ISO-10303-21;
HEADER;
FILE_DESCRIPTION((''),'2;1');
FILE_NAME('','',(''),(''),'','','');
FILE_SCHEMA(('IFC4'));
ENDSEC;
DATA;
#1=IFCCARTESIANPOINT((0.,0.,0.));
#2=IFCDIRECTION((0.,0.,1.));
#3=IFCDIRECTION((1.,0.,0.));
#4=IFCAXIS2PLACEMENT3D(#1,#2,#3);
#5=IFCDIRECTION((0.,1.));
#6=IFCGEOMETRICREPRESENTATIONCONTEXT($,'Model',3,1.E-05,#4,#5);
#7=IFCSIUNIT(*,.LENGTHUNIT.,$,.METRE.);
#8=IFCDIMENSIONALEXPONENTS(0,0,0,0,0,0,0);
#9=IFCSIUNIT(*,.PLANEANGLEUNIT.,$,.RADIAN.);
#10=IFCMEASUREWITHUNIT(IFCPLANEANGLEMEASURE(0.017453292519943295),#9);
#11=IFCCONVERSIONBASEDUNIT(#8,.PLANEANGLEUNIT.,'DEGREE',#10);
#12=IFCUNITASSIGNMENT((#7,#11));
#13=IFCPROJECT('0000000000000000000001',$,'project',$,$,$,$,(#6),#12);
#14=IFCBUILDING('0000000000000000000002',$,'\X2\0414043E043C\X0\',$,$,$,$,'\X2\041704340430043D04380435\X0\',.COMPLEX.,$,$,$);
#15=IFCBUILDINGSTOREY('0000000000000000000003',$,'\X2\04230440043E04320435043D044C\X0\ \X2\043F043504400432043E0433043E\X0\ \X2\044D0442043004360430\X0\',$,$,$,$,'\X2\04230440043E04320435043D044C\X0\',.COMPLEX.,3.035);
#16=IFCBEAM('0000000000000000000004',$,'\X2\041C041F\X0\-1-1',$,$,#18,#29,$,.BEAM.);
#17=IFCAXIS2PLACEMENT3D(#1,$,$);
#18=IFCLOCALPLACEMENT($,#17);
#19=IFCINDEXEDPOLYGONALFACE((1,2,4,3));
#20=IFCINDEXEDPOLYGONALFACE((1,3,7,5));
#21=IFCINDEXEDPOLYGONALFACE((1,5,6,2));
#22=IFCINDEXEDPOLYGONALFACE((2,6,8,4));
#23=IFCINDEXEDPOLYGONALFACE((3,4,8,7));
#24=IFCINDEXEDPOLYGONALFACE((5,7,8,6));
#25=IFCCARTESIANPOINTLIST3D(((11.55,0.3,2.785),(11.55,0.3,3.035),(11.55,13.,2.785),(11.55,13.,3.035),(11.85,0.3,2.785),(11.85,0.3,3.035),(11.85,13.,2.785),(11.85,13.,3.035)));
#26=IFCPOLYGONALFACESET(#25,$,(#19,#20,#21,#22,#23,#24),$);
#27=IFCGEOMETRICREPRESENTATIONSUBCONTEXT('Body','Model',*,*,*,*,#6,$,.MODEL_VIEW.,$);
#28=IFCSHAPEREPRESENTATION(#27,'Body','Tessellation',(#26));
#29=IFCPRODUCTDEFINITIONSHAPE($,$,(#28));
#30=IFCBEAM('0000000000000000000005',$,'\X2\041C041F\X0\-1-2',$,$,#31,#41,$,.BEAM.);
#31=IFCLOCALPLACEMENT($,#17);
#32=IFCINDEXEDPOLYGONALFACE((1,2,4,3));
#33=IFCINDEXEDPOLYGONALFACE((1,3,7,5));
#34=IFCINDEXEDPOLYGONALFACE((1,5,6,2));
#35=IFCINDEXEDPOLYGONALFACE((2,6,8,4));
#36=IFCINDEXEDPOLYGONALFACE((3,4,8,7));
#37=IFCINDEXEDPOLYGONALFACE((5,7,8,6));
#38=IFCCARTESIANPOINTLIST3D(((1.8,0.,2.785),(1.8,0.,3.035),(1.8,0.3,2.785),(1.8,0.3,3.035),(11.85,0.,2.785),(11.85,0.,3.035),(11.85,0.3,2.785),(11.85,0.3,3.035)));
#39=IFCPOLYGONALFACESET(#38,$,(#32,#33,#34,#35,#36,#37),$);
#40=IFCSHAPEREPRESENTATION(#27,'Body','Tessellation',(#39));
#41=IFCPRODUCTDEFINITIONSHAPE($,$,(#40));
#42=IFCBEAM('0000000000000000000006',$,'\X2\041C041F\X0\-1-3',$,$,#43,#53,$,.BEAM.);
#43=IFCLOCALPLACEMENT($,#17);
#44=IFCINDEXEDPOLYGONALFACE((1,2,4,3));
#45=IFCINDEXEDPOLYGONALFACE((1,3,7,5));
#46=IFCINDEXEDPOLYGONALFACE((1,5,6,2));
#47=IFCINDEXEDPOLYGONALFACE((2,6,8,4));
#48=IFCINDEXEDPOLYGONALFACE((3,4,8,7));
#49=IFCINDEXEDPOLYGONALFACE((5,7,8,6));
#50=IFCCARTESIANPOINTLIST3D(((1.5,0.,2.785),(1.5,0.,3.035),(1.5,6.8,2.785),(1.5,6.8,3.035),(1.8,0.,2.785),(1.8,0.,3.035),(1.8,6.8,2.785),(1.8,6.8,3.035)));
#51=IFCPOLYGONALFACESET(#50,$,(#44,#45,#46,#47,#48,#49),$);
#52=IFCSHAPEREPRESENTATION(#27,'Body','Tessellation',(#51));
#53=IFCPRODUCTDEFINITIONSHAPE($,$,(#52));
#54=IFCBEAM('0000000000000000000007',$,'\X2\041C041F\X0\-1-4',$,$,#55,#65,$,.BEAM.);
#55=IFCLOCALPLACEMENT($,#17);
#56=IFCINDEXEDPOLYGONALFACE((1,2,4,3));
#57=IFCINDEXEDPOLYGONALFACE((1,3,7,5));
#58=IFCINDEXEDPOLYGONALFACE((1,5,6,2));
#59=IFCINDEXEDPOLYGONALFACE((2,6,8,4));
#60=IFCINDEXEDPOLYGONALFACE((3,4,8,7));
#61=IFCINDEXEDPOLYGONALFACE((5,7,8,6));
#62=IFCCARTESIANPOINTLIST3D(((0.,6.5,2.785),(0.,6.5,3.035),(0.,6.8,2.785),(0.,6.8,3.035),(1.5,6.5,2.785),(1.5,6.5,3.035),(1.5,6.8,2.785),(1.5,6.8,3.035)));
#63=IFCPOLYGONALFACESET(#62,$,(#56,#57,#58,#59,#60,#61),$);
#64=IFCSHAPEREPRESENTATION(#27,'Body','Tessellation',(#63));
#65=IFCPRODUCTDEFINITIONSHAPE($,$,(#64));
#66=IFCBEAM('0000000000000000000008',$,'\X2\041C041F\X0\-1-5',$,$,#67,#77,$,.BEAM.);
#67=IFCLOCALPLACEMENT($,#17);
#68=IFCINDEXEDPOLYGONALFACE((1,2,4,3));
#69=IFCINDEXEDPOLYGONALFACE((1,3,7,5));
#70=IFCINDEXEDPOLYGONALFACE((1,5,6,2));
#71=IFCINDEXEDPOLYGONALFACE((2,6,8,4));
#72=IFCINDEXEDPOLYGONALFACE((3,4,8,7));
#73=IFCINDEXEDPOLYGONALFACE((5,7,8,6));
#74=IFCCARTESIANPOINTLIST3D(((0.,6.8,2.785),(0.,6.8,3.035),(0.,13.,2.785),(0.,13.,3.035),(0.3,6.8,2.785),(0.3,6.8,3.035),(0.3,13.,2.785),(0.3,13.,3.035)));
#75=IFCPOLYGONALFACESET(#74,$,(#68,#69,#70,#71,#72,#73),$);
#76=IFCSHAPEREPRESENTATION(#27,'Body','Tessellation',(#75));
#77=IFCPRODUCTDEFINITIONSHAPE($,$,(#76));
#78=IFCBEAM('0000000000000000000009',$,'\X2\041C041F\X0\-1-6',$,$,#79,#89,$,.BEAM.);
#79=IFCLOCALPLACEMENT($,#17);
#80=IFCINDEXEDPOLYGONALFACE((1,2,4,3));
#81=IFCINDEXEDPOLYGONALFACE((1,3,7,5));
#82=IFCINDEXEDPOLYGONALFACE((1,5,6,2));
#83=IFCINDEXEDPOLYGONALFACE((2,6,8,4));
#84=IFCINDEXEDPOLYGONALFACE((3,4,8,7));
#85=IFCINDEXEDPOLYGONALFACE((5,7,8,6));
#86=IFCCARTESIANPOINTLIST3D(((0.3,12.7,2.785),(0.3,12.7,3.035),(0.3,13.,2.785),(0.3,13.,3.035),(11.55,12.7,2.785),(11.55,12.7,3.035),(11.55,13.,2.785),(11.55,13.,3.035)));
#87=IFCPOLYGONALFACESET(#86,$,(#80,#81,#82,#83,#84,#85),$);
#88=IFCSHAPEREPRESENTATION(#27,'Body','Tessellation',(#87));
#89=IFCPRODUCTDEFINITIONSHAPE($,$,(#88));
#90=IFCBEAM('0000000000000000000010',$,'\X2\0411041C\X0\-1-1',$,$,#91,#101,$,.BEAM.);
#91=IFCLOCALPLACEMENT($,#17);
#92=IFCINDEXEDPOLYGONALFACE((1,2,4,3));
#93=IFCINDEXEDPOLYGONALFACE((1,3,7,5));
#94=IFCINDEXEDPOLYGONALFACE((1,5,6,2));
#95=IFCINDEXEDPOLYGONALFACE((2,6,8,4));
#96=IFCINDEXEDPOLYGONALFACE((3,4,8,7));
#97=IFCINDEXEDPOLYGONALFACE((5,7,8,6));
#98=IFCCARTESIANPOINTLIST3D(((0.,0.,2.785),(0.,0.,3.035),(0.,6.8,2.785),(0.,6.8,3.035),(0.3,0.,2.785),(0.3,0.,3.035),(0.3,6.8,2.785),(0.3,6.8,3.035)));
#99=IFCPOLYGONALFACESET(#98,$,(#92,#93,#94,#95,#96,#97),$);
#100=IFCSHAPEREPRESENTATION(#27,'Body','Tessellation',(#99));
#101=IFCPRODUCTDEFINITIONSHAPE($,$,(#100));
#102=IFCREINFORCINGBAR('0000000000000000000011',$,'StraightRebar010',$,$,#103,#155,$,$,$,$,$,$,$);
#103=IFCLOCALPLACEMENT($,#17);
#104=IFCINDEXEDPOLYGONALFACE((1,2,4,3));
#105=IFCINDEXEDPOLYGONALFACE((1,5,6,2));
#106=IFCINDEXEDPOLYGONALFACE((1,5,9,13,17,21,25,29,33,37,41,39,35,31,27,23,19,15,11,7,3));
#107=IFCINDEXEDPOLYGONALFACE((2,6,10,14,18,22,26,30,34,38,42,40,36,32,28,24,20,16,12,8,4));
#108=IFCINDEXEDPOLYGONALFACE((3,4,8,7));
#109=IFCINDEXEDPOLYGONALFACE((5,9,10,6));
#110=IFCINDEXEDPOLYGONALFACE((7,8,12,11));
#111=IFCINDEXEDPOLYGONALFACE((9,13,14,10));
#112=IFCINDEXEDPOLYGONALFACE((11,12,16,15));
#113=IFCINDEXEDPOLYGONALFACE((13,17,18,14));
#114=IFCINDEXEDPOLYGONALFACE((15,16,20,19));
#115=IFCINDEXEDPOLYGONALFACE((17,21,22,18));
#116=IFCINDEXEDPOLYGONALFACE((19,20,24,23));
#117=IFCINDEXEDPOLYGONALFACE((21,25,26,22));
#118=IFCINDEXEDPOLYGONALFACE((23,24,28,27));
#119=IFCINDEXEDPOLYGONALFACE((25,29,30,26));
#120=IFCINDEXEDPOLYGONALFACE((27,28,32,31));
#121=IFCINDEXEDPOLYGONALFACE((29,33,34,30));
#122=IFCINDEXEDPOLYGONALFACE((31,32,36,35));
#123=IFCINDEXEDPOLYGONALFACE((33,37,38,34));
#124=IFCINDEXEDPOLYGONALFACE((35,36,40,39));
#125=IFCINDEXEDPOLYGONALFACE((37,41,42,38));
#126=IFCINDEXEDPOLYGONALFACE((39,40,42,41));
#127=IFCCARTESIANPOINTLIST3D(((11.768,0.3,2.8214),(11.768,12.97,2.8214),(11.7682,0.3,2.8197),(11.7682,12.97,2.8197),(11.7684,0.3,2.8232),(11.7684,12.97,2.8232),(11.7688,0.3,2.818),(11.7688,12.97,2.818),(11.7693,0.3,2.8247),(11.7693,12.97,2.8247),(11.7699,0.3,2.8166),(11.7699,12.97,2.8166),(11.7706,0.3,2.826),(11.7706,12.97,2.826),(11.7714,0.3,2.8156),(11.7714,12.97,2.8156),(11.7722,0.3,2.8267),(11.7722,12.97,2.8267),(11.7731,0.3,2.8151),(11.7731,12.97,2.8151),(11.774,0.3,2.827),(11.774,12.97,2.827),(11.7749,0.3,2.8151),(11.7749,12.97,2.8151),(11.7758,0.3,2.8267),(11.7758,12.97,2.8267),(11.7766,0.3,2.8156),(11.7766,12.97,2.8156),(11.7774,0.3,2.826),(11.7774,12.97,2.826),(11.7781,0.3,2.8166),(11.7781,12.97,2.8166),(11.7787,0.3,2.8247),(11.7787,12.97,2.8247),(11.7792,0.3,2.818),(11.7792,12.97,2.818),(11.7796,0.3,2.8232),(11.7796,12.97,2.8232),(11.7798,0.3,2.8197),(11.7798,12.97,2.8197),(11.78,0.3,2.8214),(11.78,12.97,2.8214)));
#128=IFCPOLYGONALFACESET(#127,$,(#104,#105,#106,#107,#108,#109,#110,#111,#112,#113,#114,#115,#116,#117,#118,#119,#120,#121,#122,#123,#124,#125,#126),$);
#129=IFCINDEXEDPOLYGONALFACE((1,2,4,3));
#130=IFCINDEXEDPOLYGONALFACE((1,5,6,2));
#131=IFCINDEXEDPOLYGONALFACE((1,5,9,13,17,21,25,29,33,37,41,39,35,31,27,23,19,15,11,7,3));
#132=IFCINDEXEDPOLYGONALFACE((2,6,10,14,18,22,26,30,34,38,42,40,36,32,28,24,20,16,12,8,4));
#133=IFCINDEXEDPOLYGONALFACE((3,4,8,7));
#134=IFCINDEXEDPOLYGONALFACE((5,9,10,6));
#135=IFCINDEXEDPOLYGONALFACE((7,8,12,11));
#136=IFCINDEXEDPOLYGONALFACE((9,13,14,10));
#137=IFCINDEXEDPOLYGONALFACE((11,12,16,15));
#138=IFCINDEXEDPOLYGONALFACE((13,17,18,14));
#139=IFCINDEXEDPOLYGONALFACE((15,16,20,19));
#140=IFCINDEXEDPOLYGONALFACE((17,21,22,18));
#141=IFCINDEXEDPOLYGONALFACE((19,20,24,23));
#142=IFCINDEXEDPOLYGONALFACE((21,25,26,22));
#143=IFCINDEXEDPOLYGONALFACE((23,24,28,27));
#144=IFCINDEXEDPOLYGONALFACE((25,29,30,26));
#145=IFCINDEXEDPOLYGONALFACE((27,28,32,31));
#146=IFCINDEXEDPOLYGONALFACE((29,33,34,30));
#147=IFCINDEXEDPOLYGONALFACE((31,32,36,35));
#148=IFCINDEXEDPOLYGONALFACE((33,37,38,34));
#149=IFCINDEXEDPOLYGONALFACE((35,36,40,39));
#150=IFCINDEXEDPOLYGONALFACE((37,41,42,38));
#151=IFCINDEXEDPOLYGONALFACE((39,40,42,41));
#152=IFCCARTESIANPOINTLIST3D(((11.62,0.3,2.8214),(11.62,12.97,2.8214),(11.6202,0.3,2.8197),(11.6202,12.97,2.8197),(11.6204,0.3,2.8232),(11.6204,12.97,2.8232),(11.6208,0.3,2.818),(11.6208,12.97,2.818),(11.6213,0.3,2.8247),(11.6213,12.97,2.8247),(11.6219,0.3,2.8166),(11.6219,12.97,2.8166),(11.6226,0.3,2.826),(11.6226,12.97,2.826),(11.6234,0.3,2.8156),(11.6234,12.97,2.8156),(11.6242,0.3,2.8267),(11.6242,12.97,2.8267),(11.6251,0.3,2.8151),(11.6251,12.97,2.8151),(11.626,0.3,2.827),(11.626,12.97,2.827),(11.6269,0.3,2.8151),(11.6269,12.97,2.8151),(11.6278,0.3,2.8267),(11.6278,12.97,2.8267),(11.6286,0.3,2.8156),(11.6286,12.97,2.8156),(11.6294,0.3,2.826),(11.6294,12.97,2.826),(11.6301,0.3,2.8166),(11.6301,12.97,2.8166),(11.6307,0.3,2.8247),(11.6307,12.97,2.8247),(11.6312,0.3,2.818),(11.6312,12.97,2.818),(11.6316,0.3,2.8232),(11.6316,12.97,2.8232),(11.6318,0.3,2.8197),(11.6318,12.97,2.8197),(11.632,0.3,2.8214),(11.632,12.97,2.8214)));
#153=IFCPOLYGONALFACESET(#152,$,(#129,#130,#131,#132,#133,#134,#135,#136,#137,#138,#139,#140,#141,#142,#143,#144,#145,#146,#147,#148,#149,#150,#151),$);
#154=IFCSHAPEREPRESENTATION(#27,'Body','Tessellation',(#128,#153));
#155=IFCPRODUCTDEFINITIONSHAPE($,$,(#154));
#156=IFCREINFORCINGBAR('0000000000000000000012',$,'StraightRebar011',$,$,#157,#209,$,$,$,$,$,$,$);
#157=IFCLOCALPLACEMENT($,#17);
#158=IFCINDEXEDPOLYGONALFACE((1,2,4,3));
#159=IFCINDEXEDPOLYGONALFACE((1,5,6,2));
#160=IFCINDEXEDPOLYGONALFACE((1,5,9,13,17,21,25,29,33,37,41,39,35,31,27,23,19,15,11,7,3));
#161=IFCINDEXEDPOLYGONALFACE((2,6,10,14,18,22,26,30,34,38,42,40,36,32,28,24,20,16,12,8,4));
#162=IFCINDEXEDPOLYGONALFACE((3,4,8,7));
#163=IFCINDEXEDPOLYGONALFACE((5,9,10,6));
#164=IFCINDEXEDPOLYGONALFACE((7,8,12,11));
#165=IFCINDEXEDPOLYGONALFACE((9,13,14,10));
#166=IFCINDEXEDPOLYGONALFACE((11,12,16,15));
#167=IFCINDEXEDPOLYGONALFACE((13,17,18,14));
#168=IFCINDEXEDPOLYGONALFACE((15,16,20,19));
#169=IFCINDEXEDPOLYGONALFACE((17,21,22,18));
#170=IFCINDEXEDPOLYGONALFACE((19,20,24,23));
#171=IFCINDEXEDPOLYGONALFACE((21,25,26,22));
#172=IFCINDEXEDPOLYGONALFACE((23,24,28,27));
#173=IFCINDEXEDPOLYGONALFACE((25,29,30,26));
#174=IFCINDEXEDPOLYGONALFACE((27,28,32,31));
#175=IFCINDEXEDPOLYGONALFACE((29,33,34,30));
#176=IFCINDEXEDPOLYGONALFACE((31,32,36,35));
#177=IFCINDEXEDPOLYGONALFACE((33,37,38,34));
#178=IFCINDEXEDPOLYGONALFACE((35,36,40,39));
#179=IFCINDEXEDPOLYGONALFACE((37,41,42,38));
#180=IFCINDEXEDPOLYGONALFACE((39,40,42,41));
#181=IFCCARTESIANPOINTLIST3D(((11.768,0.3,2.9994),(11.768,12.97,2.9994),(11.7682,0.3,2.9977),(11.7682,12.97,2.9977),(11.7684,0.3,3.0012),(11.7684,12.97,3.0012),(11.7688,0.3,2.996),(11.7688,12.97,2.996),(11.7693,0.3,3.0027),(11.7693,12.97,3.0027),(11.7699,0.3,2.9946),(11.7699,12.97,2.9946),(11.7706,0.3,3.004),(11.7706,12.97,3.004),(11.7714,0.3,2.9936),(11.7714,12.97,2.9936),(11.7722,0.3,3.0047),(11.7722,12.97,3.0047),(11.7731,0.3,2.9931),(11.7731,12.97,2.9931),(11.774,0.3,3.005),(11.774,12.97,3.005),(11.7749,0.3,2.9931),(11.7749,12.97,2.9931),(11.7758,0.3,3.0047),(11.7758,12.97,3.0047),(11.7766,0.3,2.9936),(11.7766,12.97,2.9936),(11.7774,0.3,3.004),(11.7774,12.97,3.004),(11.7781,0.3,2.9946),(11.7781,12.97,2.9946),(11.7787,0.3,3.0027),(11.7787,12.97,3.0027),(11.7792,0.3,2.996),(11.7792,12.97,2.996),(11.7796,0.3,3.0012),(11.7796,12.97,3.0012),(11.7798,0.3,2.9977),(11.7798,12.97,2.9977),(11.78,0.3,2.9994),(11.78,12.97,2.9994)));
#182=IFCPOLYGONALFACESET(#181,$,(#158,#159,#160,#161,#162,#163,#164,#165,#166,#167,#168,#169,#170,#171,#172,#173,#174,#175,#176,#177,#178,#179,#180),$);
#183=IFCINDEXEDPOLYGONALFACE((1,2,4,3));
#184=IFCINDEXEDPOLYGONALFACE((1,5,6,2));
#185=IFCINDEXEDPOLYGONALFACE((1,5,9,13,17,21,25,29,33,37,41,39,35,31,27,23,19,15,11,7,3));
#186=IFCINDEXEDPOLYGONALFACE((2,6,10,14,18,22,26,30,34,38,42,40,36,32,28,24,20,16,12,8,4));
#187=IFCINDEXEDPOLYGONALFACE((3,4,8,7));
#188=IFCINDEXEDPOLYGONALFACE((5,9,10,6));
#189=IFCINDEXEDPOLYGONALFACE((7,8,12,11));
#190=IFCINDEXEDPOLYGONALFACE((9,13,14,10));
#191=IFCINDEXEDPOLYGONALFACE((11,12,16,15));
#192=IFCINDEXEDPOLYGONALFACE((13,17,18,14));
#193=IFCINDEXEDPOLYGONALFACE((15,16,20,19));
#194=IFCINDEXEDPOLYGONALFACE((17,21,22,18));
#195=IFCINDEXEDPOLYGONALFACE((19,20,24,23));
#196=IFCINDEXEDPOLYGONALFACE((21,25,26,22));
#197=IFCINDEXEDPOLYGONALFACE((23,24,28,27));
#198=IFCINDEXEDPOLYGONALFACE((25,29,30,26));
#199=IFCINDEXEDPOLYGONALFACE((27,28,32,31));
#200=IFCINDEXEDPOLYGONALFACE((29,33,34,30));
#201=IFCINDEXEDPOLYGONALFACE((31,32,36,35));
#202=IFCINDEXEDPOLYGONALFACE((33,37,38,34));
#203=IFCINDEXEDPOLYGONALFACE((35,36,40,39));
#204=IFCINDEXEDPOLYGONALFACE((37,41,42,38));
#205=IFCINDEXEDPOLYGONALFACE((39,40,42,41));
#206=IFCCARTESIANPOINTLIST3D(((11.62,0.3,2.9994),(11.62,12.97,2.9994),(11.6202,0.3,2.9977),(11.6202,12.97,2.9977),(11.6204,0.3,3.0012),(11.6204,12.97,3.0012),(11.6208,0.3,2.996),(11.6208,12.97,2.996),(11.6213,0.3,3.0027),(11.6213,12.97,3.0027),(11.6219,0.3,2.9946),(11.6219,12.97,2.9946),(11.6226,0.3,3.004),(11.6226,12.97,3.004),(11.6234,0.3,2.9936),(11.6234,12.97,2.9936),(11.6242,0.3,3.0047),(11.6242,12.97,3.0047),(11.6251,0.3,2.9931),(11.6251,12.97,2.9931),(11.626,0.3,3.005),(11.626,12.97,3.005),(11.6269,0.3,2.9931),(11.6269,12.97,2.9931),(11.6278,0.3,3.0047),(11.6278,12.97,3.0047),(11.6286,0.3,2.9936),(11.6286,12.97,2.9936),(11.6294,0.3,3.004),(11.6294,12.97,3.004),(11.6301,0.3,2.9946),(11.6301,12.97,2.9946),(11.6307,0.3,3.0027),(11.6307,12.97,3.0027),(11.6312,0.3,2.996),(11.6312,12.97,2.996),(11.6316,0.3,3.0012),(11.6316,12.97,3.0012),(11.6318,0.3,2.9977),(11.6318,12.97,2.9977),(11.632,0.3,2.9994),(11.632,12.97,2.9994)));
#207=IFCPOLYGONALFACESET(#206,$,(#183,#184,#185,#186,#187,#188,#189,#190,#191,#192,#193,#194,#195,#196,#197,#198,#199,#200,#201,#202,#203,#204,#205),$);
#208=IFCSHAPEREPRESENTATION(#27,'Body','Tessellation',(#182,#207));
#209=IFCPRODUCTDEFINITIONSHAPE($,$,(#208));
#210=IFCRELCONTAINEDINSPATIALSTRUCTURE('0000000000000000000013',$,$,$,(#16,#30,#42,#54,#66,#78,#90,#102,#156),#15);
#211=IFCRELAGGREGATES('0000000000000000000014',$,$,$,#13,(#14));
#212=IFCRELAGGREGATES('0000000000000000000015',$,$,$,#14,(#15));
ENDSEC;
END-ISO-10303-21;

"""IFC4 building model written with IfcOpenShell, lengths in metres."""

from ifc_helpers import new_model, entity, si_unit, converted_unit, direction, frame, frame_2d, origin_with_axes, origin_2d_with_axis, place, context, subcontext, project, spatial, rectangle, extrude, element, save


model = new_model("IFC4")

# Units and contexts
model_context = context("Model", 3, precision=1e-05, world=origin_with_axes(), true_north=direction((0.0, 1.0)))
body_context = subcontext(model_context, "Body", "Model", "MODEL_VIEW")
ifc_project = project(units=[si_unit("LENGTHUNIT", "METRE"), converted_unit("PLANEANGLEUNIT", "DEGREE", entity("IfcPlaneAngleMeasure", 0.017453292519943295), si_unit("PLANEANGLEUNIT", "RADIAN"), dimensions=[0, 0, 0, 0, 0, 0, 0])], contexts=[model_context])

# Building, storey
building = spatial("IfcBuilding", under=ifc_project, Name="Дом", LongName="Здание", CompositionType="COMPLEX")
storey = spatial("IfcBuildingStorey", under=building, Name="Уровень первого этажа", LongName="Уровень", CompositionType="COMPLEX", Elevation=3.035)

# Beams
placement = place(None, origin_with_axes())
element("IfcBeam", 1, at=placement, inside=storey, Name="МП-1-1", PredefinedType="BEAM", context=body_context, shape_type="SweptSolid", body=[
    extrude(rectangle(XDim=0.3, YDim=12.7, at=origin_2d_with_axis()), frame((11.7, 6.65, 2.785), z_axis=(0.0, 0.0, 1.0), x_axis=(1.0, 0.0, 0.0)), (0.0, 0.0, 1.0), 0.25),
])
element("IfcBeam", 2, at=placement, inside=storey, Name="МП-1-2", PredefinedType="BEAM", context=body_context, shape_type="SweptSolid", body=[
    extrude(rectangle(XDim=10.05, YDim=0.3, at=frame_2d((0.0, 0.0), x_axis=(1.0, 0.0))), frame((6.825, 0.15, 2.785), z_axis=(0.0, 0.0, 1.0), x_axis=(1.0, 0.0, 0.0)), (0.0, 0.0, 1.0), 0.25),
])
element("IfcBeam", 3, at=placement, inside=storey, Name="МП-1-3", PredefinedType="BEAM", context=body_context, shape_type="SweptSolid", body=[
    extrude(rectangle(XDim=0.3, YDim=6.8, at=origin_2d_with_axis()), frame((1.65, 3.4, 2.785), z_axis=(0.0, 0.0, 1.0), x_axis=(1.0, 0.0, 0.0)), (0.0, 0.0, 1.0), 0.25),
])
element("IfcBeam", 4, at=placement, inside=storey, Name="МП-1-4", PredefinedType="BEAM", context=body_context, shape_type="SweptSolid", body=[
    extrude(rectangle(XDim=1.5, YDim=0.3, at=frame_2d((0.0, 0.0), x_axis=(1.0, 0.0))), frame((0.75, 6.65, 2.785), z_axis=(0.0, 0.0, 1.0), x_axis=(1.0, 0.0, 0.0)), (0.0, 0.0, 1.0), 0.25),
])
element("IfcBeam", 5, at=placement, inside=storey, Name="МП-1-5", PredefinedType="BEAM", context=body_context, shape_type="SweptSolid", body=[
    extrude(rectangle(XDim=0.3, YDim=6.2, at=frame_2d((0.0, 0.0), x_axis=(1.0, 0.0))), frame((0.15, 9.9, 2.785), z_axis=(0.0, 0.0, 1.0), x_axis=(1.0, 0.0, 0.0)), (0.0, 0.0, 1.0), 0.25),
])
element("IfcBeam", 6, at=placement, inside=storey, Name="МП-1-6", PredefinedType="BEAM", context=body_context, shape_type="SweptSolid", body=[
    extrude(rectangle(XDim=11.25, YDim=0.3, at=origin_2d_with_axis()), frame((5.925, 12.85, 2.785), z_axis=(0.0, 0.0, 1.0), x_axis=(1.0, 0.0, 0.0)), (0.0, 0.0, 1.0), 0.25),
])
element("IfcBeam", 7, at=placement, inside=storey, Name="БМ-1-1", PredefinedType="BEAM", context=body_context, shape_type="SweptSolid", body=[
    extrude(rectangle(XDim=0.3, YDim=6.8, at=origin_2d_with_axis()), frame((0.15, 3.4, 2.785), z_axis=(0.0, 0.0, 1.0), x_axis=(1.0, 0.0, 0.0)), (0.0, 0.0, 1.0), 0.25),
])

# Reinforcing bars
element("IfcReinforcingBar", 8, at=placement, inside=storey, Name="StraightRebar010", context=body_context, shape_type="SweptSolid", body=[
    entity("IfcSweptDiskSolid", entity("IfcCompositeCurve", [entity("IfcCompositeCurveSegment", "CONTINUOUS", True, entity("IfcPolyline", [entity("IfcCartesianPoint", [11.774, 0.3, 2.821]), entity("IfcCartesianPoint", [11.774, 12.97, 2.821])]))], False), 0.006),
    entity("IfcSweptDiskSolid", entity("IfcCompositeCurve", [entity("IfcCompositeCurveSegment", "CONTINUOUS", True, entity("IfcPolyline", [entity("IfcCartesianPoint", [11.626, 0.3, 2.821]), entity("IfcCartesianPoint", [11.626, 12.97, 2.821])]))], False), 0.006),
])
element("IfcReinforcingBar", 9, at=placement, inside=storey, Name="StraightRebar011", context=body_context, shape_type="SweptSolid", body=[
    entity("IfcSweptDiskSolid", entity("IfcCompositeCurve", [entity("IfcCompositeCurveSegment", "CONTINUOUS", True, entity("IfcPolyline", [entity("IfcCartesianPoint", [11.774, 0.3, 2.999]), entity("IfcCartesianPoint", [11.774, 12.97, 2.999])]))], False), 0.006),
    entity("IfcSweptDiskSolid", entity("IfcCompositeCurve", [entity("IfcCompositeCurveSegment", "CONTINUOUS", True, entity("IfcPolyline", [entity("IfcCartesianPoint", [11.626, 0.3, 2.999]), entity("IfcCartesianPoint", [11.626, 12.97, 2.999])]))], False), 0.006),
])

save(model, "model.ifc")
